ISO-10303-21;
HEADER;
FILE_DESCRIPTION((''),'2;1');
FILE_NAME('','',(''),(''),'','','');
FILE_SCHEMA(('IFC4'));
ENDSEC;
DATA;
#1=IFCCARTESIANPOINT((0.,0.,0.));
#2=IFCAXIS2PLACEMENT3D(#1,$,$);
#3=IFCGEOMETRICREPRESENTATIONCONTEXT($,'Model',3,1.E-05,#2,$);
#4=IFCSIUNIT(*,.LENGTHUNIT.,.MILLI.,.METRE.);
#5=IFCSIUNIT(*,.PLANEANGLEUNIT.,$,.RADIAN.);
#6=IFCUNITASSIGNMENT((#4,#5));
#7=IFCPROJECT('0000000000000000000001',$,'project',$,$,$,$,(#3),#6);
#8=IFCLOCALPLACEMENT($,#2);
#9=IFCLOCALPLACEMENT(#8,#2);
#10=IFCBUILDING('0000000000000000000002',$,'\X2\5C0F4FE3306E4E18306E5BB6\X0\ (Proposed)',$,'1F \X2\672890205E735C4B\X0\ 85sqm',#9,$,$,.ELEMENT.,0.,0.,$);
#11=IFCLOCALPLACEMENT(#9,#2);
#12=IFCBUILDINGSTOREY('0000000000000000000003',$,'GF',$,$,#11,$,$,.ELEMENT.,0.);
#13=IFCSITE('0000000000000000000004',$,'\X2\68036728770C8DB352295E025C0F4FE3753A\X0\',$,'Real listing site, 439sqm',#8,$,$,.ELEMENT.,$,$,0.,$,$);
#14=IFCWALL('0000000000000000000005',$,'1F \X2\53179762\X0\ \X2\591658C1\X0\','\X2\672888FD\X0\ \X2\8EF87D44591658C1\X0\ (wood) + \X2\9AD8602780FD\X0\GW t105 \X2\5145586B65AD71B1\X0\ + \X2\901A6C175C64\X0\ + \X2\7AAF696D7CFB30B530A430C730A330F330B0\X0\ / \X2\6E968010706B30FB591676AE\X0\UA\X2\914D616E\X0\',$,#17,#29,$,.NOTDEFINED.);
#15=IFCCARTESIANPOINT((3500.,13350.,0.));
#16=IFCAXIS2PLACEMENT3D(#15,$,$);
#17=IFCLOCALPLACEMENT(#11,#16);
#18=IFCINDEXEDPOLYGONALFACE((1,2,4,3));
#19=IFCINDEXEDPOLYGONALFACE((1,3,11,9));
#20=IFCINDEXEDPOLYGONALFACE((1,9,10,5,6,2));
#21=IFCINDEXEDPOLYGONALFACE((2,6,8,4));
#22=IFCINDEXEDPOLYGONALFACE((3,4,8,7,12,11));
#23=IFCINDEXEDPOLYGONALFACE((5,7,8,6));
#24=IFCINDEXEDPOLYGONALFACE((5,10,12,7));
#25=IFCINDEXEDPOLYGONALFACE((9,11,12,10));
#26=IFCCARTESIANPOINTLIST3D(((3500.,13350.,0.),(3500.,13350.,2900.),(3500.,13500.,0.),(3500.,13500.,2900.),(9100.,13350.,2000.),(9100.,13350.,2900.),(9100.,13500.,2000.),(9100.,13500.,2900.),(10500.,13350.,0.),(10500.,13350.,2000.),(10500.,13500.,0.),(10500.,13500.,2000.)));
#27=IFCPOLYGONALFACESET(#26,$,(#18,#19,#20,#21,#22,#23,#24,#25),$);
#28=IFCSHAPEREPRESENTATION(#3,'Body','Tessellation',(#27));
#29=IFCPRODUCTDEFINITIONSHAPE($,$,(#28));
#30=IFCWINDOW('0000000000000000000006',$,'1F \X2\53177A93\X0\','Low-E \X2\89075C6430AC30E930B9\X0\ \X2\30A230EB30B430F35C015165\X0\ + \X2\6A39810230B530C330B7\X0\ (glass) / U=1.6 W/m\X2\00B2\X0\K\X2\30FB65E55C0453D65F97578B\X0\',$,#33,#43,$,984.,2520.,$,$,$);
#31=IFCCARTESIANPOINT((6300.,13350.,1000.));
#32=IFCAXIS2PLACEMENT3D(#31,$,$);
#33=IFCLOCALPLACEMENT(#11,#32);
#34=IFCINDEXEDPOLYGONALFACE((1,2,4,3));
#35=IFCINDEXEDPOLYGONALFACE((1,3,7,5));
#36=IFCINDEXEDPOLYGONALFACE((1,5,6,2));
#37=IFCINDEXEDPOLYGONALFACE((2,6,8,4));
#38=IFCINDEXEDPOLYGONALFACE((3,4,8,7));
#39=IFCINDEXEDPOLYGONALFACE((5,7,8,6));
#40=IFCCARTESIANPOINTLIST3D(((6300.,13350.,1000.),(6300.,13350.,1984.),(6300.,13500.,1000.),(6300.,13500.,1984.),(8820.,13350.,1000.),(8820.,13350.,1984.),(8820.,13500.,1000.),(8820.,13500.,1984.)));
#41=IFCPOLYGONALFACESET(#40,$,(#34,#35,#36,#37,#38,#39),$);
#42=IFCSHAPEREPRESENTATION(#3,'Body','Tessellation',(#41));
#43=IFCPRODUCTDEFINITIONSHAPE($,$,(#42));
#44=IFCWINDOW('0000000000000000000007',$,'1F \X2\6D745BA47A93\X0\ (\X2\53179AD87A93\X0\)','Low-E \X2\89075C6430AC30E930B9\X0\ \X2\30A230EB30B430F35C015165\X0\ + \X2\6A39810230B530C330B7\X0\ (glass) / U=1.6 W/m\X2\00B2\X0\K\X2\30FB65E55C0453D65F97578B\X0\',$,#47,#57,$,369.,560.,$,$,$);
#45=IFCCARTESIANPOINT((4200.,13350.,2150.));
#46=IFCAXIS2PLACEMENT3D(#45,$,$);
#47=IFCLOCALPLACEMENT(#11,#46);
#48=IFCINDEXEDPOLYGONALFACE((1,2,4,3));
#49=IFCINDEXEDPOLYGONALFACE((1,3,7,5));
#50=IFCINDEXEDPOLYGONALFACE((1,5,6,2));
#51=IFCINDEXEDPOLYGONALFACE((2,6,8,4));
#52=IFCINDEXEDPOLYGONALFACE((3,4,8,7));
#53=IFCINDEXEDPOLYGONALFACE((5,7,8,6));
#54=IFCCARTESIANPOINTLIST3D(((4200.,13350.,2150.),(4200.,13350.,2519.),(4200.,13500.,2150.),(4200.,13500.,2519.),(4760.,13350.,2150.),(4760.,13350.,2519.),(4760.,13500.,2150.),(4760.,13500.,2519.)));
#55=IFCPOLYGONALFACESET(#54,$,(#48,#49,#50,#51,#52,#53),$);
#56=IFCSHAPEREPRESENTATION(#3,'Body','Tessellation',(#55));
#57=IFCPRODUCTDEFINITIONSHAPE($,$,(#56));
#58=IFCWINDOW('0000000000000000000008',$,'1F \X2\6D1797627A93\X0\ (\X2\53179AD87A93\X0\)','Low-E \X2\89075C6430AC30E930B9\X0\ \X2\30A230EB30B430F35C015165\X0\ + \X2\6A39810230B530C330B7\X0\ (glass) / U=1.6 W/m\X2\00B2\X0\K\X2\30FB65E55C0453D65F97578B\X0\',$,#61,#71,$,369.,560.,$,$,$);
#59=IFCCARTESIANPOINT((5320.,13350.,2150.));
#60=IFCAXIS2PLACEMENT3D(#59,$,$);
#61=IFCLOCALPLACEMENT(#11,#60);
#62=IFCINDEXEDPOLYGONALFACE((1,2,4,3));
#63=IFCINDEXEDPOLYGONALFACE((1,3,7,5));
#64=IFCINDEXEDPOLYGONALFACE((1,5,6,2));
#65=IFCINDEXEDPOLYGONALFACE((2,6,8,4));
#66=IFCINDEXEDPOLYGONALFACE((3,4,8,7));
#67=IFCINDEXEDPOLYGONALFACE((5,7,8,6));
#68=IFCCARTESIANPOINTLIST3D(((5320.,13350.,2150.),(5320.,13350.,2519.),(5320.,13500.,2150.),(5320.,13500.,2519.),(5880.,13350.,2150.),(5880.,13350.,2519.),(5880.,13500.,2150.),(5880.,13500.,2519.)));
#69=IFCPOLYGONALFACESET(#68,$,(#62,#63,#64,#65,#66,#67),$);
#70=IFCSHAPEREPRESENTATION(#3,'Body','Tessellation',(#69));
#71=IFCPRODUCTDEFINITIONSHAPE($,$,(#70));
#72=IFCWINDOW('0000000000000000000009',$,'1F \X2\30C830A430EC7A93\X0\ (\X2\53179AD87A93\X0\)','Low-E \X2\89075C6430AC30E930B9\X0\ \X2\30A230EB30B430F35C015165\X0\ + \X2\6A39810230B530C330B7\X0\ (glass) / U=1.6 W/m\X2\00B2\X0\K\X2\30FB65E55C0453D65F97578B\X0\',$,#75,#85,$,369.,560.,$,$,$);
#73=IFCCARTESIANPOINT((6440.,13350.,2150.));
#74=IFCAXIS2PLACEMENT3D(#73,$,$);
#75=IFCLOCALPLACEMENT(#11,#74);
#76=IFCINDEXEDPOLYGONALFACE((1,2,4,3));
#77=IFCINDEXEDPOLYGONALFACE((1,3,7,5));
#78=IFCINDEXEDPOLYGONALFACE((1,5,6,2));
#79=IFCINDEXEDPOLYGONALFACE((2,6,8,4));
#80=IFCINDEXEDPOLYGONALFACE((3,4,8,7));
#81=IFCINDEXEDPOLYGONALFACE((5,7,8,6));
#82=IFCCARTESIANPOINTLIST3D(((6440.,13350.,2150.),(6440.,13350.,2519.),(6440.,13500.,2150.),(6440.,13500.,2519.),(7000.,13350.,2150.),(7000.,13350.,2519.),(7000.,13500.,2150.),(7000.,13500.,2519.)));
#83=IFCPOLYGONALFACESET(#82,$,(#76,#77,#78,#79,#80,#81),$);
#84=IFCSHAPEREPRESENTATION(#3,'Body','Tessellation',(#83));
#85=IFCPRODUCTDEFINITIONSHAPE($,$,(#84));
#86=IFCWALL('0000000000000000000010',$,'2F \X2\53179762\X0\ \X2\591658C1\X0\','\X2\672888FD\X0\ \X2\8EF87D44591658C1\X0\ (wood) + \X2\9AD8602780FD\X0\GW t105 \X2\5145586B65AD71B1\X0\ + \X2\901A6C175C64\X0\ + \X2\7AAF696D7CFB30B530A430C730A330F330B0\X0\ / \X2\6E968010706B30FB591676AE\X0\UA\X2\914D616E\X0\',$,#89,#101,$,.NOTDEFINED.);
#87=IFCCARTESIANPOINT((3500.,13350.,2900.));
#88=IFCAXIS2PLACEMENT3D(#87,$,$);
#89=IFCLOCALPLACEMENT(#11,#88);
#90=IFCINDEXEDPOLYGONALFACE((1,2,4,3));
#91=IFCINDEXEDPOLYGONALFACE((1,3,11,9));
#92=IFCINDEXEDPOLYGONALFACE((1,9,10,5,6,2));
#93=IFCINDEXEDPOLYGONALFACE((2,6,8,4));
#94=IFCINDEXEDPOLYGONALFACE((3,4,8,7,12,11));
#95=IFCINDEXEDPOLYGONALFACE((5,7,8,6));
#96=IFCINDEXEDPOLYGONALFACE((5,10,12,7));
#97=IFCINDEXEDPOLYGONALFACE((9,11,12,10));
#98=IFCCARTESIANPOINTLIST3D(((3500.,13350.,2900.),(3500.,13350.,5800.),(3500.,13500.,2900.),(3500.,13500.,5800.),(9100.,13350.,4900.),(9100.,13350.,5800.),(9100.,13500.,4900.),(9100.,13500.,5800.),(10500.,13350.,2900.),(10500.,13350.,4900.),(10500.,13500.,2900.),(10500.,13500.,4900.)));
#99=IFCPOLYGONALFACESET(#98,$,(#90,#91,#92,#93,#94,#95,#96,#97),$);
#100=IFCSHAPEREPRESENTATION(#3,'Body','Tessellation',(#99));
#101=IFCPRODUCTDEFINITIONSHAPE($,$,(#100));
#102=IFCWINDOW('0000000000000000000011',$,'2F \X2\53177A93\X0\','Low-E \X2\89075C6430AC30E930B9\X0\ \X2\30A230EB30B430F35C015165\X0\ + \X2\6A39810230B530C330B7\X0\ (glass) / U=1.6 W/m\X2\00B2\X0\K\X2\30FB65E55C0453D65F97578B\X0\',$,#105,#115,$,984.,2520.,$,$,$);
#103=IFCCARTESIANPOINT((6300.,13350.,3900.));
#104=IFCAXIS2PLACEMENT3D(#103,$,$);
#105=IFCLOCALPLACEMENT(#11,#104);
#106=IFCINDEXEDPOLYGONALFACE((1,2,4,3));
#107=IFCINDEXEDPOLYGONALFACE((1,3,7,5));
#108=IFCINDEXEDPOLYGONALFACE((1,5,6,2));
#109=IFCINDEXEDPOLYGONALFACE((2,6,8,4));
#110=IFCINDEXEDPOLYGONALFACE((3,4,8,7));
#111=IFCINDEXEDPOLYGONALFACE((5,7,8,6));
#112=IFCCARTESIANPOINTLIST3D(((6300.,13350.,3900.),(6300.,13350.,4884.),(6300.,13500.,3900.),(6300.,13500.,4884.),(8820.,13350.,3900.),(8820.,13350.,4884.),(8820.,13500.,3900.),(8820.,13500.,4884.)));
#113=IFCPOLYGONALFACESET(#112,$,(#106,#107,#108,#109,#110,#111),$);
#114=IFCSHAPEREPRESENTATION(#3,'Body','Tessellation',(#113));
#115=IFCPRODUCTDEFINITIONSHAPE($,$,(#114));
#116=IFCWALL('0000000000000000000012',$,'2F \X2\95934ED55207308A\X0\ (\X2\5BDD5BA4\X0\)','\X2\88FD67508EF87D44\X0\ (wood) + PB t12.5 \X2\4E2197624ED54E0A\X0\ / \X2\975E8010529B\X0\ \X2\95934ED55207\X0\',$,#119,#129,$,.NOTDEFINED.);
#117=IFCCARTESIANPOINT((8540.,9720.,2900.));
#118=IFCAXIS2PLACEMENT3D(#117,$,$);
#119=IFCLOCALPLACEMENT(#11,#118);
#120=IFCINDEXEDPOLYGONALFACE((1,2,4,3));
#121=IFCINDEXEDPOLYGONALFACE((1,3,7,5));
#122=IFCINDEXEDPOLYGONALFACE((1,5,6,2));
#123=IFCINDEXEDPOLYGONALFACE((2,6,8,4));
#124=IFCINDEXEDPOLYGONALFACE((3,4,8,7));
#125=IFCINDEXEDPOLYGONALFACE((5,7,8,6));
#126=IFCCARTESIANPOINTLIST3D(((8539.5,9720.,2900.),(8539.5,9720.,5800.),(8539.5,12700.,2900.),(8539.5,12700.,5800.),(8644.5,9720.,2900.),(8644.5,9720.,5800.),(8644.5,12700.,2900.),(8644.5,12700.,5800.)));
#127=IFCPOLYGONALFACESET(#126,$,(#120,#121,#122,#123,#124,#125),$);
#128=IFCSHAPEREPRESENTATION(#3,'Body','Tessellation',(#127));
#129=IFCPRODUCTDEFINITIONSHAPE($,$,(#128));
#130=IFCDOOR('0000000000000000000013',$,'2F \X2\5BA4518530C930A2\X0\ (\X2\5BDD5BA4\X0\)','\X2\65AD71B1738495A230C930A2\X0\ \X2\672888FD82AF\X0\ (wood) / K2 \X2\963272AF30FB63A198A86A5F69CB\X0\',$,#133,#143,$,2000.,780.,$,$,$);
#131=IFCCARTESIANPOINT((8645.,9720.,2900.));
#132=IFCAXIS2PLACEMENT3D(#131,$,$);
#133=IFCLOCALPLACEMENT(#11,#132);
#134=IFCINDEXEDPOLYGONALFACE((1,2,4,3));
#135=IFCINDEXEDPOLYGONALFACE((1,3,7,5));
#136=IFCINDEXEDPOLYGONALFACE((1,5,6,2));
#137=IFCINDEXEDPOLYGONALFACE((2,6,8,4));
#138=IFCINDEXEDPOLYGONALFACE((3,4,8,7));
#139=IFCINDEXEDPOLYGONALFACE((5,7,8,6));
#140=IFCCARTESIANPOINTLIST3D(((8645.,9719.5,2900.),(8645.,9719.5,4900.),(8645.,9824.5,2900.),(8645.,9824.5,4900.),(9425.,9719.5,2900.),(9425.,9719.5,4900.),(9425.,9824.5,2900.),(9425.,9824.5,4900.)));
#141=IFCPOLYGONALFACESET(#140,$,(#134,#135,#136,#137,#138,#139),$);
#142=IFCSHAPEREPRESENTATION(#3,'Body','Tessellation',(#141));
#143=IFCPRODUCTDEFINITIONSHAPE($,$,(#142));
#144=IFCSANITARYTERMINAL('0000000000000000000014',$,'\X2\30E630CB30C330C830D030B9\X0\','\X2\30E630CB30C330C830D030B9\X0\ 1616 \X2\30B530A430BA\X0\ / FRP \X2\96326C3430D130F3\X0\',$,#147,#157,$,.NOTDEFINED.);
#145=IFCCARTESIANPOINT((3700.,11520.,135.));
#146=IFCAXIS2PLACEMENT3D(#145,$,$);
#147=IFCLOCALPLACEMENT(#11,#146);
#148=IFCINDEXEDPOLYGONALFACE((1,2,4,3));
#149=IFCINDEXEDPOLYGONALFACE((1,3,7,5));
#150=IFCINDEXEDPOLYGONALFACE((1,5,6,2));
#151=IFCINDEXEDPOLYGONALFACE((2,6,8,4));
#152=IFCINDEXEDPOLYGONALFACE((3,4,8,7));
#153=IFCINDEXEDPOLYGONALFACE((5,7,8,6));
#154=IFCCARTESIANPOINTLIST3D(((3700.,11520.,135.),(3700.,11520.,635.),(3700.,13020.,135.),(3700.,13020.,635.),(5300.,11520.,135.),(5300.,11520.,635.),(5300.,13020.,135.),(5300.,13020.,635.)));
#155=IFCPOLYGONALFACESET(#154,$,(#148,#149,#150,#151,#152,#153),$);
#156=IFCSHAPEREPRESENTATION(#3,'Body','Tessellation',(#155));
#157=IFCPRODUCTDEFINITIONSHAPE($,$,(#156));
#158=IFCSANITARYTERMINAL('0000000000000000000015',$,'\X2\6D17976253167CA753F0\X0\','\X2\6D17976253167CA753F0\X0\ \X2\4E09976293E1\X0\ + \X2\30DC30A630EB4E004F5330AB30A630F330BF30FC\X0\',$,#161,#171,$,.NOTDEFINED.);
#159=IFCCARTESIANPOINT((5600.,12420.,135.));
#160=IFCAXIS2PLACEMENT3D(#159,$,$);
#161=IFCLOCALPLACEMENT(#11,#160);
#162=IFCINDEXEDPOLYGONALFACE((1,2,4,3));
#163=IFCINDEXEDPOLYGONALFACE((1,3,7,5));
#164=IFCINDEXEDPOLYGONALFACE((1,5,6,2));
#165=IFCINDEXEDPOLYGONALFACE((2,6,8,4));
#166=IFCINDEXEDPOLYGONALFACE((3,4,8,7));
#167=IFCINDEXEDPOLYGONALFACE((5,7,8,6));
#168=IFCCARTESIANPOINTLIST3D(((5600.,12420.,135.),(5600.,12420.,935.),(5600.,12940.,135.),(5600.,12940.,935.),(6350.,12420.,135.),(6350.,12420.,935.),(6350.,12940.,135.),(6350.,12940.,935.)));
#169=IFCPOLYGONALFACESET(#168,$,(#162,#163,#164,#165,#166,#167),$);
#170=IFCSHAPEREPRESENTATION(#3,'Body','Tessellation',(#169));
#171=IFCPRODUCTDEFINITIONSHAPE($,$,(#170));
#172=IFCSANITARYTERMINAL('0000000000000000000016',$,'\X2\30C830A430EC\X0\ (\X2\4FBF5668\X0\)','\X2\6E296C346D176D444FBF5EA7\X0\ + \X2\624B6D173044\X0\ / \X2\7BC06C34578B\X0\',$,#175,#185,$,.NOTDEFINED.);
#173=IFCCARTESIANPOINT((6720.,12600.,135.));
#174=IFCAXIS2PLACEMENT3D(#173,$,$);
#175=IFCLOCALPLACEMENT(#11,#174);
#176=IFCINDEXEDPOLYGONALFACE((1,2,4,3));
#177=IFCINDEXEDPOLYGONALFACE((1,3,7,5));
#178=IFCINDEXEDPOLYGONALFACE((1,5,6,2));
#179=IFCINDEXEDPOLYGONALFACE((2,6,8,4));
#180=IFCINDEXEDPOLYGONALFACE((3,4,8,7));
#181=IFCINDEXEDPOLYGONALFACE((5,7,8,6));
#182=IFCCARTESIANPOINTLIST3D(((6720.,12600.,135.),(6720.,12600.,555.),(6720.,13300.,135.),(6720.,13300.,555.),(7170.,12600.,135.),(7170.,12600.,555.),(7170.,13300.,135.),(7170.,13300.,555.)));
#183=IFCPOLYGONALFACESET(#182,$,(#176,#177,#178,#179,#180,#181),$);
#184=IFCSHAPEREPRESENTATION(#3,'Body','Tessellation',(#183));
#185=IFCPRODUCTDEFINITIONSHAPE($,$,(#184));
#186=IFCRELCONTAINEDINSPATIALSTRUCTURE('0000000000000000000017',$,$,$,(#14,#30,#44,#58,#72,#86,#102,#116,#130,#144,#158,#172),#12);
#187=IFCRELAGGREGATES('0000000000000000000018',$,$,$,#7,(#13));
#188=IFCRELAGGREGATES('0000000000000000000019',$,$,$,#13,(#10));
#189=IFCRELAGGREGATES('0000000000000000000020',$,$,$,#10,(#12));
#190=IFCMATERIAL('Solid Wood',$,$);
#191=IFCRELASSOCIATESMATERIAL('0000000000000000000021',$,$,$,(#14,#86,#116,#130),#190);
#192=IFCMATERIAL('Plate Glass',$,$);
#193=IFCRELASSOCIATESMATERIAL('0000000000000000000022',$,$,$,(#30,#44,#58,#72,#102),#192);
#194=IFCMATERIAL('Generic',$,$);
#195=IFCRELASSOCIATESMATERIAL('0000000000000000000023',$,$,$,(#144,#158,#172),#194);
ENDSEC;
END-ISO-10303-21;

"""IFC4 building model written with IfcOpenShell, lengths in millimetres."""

from ifc_helpers import new_model, si_unit, frame, frame_2d, origin, place, context, project, spatial, rectangle, extrude, material, element, fill, save


model = new_model("IFC4")

# Units and contexts
model_context = context("Model", 3, precision=1e-05, world=origin())
ifc_project = project(units=[si_unit("LENGTHUNIT", "METRE", prefix="MILLI"), si_unit("PLANEANGLEUNIT", "RADIAN")], contexts=[model_context])

# Site, building, storey
site_placement = place(None, origin())
site = spatial("IfcSite", under=ifc_project, at=site_placement, Name="栃木県足利市小俣町", ObjectType="Real listing site, 439sqm", CompositionType="ELEMENT", RefElevation=0.0)
building_placement = place(site_placement, origin())
building = spatial("IfcBuilding", under=site, at=building_placement, Name="小俣の丘の家 (Proposed)", ObjectType="1F 木造平屋 85sqm", CompositionType="ELEMENT", ElevationOfRefHeight=0.0, ElevationOfTerrain=0.0)
storey_placement = place(building_placement, origin())
storey = spatial("IfcBuildingStorey", under=building, at=storey_placement, Name="GF", CompositionType="ELEMENT", Elevation=0.0)

# Wall, openings, windows
ifc_material_1 = material(Name="Solid Wood")
wall_1_placement = place(storey_placement, frame((3500.0, 13350.0, 0.0)))
wall_1 = element("IfcWall", 1, at=wall_1_placement, inside=storey, material=ifc_material_1, Name="1F 北面 外壁", Description="木製 軸組外壁 (wood) + 高性能GW t105 充填断熱 + 通気層 + 窯業系サイディング / 準耐火・外皮UA配慮", PredefinedType="NOTDEFINED", context=model_context, shape_type="SweptSolid", body=[
    extrude(rectangle(XDim=7000.0, YDim=150.0, at=frame_2d((3500.0, 75.0))), frame((3500.0, 13350.0, 0.0)), (0.0, 0.0, 1.0), 2900.0),
])
opening_1_placement = place(storey_placement, frame((6300.0, 13350.0, 1000.0)))
opening_1 = element("IfcOpeningElement", 2, at=opening_1_placement, cuts=wall_1, PredefinedType="NOTDEFINED", context=model_context, shape_type="SweptSolid", body=[
    extrude(rectangle(XDim=2520.0, YDim=150.0, at=frame_2d((1260.0, 75.0))), frame((6300.0, 13350.0, 1000.0)), (0.0, 0.0, 1.0), 984.0),
])
opening_2_placement = place(storey_placement, frame((4200.0, 13350.0, 2150.0)))
opening_2 = element("IfcOpeningElement", 3, at=opening_2_placement, cuts=wall_1, PredefinedType="NOTDEFINED", context=model_context, shape_type="SweptSolid", body=[
    extrude(rectangle(XDim=560.0, YDim=150.0, at=frame_2d((280.0, 75.0))), frame((4200.0, 13350.0, 2150.0)), (0.0, 0.0, 1.0), 369.0),
])
opening_3_placement = place(storey_placement, frame((5320.0, 13350.0, 2150.0)))
opening_3 = element("IfcOpeningElement", 4, at=opening_3_placement, cuts=wall_1, PredefinedType="NOTDEFINED", context=model_context, shape_type="SweptSolid", body=[
    extrude(rectangle(XDim=560.0, YDim=150.0, at=frame_2d((280.0, 75.0))), frame((5320.0, 13350.0, 2150.0)), (0.0, 0.0, 1.0), 369.0),
])
opening_4_placement = place(storey_placement, frame((6440.0, 13350.0, 2150.0)))
opening_4 = element("IfcOpeningElement", 5, at=opening_4_placement, cuts=wall_1, PredefinedType="NOTDEFINED", context=model_context, shape_type="SweptSolid", body=[
    extrude(rectangle(XDim=560.0, YDim=150.0, at=frame_2d((280.0, 75.0))), frame((6440.0, 13350.0, 2150.0)), (0.0, 0.0, 1.0), 369.0),
])
ifc_material_2 = material(Name="Plate Glass")
window_1_placement = place(storey_placement, frame((6300.0, 13350.0, 1000.0)))
window_1 = element("IfcWindow", 6, at=window_1_placement, inside=storey, material=ifc_material_2, Name="1F 北窓", Description="Low-E 複層ガラス アルゴン封入 + 樹脂サッシ (glass) / U=1.6 W/m²K・日射取得型", OverallHeight=984.0, OverallWidth=2520.0, context=model_context, shape_type="SweptSolid", body=[
    extrude(rectangle(XDim=2520.0, YDim=150.0, at=frame_2d((1260.0, 75.0))), frame((6300.0, 13350.0, 1000.0)), (0.0, 0.0, 1.0), 984.0),
])
fill(opening_1, window_1)
window_2_placement = place(storey_placement, frame((4200.0, 13350.0, 2150.0)))
window_2 = element("IfcWindow", 7, at=window_2_placement, inside=storey, material=ifc_material_2, Name="1F 浴室窓 (北高窓)", Description="Low-E 複層ガラス アルゴン封入 + 樹脂サッシ (glass) / U=1.6 W/m²K・日射取得型", OverallHeight=369.0, OverallWidth=560.0, context=model_context, shape_type="SweptSolid", body=[
    extrude(rectangle(XDim=560.0, YDim=150.0, at=frame_2d((280.0, 75.0))), frame((4200.0, 13350.0, 2150.0)), (0.0, 0.0, 1.0), 369.0),
])
fill(opening_2, window_2)
window_3_placement = place(storey_placement, frame((5320.0, 13350.0, 2150.0)))
window_3 = element("IfcWindow", 8, at=window_3_placement, inside=storey, material=ifc_material_2, Name="1F 洗面窓 (北高窓)", Description="Low-E 複層ガラス アルゴン封入 + 樹脂サッシ (glass) / U=1.6 W/m²K・日射取得型", OverallHeight=369.0, OverallWidth=560.0, context=model_context, shape_type="SweptSolid", body=[
    extrude(rectangle(XDim=560.0, YDim=150.0, at=frame_2d((280.0, 75.0))), frame((5320.0, 13350.0, 2150.0)), (0.0, 0.0, 1.0), 369.0),
])
fill(opening_3, window_3)
window_4_placement = place(storey_placement, frame((6440.0, 13350.0, 2150.0)))
window_4 = element("IfcWindow", 9, at=window_4_placement, inside=storey, material=ifc_material_2, Name="1F トイレ窓 (北高窓)", Description="Low-E 複層ガラス アルゴン封入 + 樹脂サッシ (glass) / U=1.6 W/m²K・日射取得型", OverallHeight=369.0, OverallWidth=560.0, context=model_context, shape_type="SweptSolid", body=[
    extrude(rectangle(XDim=560.0, YDim=150.0, at=frame_2d((280.0, 75.0))), frame((6440.0, 13350.0, 2150.0)), (0.0, 0.0, 1.0), 369.0),
])
fill(opening_4, window_4)

# Wall, opening, window
wall_2_placement = place(storey_placement, frame((3500.0, 13350.0, 2900.0)))
wall_2 = element("IfcWall", 10, at=wall_2_placement, inside=storey, material=ifc_material_1, Name="2F 北面 外壁", Description="木製 軸組外壁 (wood) + 高性能GW t105 充填断熱 + 通気層 + 窯業系サイディング / 準耐火・外皮UA配慮", PredefinedType="NOTDEFINED", context=model_context, shape_type="SweptSolid", body=[
    extrude(rectangle(XDim=7000.0, YDim=150.0, at=frame_2d((3500.0, 75.0))), frame((3500.0, 13350.0, 2900.0)), (0.0, 0.0, 1.0), 2900.0),
])
opening_5_placement = place(storey_placement, frame((6300.0, 13350.0, 3900.0)))
opening_5 = element("IfcOpeningElement", 11, at=opening_5_placement, cuts=wall_2, PredefinedType="NOTDEFINED", context=model_context, shape_type="SweptSolid", body=[
    extrude(rectangle(XDim=2520.0, YDim=150.0, at=frame_2d((1260.0, 75.0))), frame((6300.0, 13350.0, 3900.0)), (0.0, 0.0, 1.0), 984.0),
])
window_5_placement = place(storey_placement, frame((6300.0, 13350.0, 3900.0)))
window_5 = element("IfcWindow", 12, at=window_5_placement, inside=storey, material=ifc_material_2, Name="2F 北窓", Description="Low-E 複層ガラス アルゴン封入 + 樹脂サッシ (glass) / U=1.6 W/m²K・日射取得型", OverallHeight=984.0, OverallWidth=2520.0, context=model_context, shape_type="SweptSolid", body=[
    extrude(rectangle(XDim=2520.0, YDim=150.0, at=frame_2d((1260.0, 75.0))), frame((6300.0, 13350.0, 3900.0)), (0.0, 0.0, 1.0), 984.0),
])
fill(opening_5, window_5)

# Wall
wall_3_placement = place(storey_placement, frame((8540.0, 9720.0, 2900.0)))
element("IfcWall", 13, at=wall_3_placement, inside=storey, material=ifc_material_1, Name="2F 間仕切り (寝室)", Description="製材軸組 (wood) + PB t12.5 両面仕上 / 非耐力 間仕切", PredefinedType="NOTDEFINED", context=model_context, shape_type="SweptSolid", body=[
    extrude(rectangle(XDim=105.0, YDim=2980.0, at=frame_2d((52.0, 1490.0))), frame((8540.0, 9720.0, 2900.0)), (0.0, 0.0, 1.0), 2900.0),
])

# Door
door_1_placement = place(storey_placement, frame((8645.0, 9720.0, 2900.0)))
element("IfcDoor", 14, at=door_1_placement, inside=storey, material=ifc_material_1, Name="2F 室内ドア (寝室)", Description="断熱玄関ドア 木製芯 (wood) / K2 防犯・採風機構", OverallHeight=2000.0, OverallWidth=780.0, context=model_context, shape_type="SweptSolid", body=[
    extrude(rectangle(XDim=780.0, YDim=105.0, at=frame_2d((390.0, 52.0))), frame((8645.0, 9720.0, 2900.0)), (0.0, 0.0, 1.0), 2000.0),
])

# Sanitary terminals
ifc_material_3 = material(Name="Generic")
sanitary_terminal_1_placement = place(storey_placement, frame((3700.0, 11520.0, 135.0)))
element("IfcSanitaryTerminal", 15, at=sanitary_terminal_1_placement, inside=storey, material=ifc_material_3, Name="ユニットバス", Description="ユニットバス 1616 サイズ / FRP 防水パン", PredefinedType="NOTDEFINED", context=model_context, shape_type="SweptSolid", body=[
    extrude(rectangle(XDim=1600.0, YDim=1500.0, at=frame_2d((800.0, 750.0))), frame((3700.0, 11520.0, 135.0)), (0.0, 0.0, 1.0), 500.0),
])
sanitary_terminal_2_placement = place(storey_placement, frame((5600.0, 12420.0, 135.0)))
element("IfcSanitaryTerminal", 16, at=sanitary_terminal_2_placement, inside=storey, material=ifc_material_3, Name="洗面化粧台", Description="洗面化粧台 三面鏡 + ボウル一体カウンター", PredefinedType="NOTDEFINED", context=model_context, shape_type="SweptSolid", body=[
    extrude(rectangle(XDim=750.0, YDim=520.0, at=frame_2d((375.0, 260.0))), frame((5600.0, 12420.0, 135.0)), (0.0, 0.0, 1.0), 800.0),
])
sanitary_terminal_3_placement = place(storey_placement, frame((6720.0, 12600.0, 135.0)))
element("IfcSanitaryTerminal", 17, at=sanitary_terminal_3_placement, inside=storey, material=ifc_material_3, Name="トイレ (便器)", Description="温水洗浄便座 + 手洗い / 節水型", PredefinedType="NOTDEFINED", context=model_context, shape_type="SweptSolid", body=[
    extrude(rectangle(XDim=450.0, YDim=700.0, at=frame_2d((225.0, 350.0))), frame((6720.0, 12600.0, 135.0)), (0.0, 0.0, 1.0), 420.0),
])

save(model, "model.ifc")
